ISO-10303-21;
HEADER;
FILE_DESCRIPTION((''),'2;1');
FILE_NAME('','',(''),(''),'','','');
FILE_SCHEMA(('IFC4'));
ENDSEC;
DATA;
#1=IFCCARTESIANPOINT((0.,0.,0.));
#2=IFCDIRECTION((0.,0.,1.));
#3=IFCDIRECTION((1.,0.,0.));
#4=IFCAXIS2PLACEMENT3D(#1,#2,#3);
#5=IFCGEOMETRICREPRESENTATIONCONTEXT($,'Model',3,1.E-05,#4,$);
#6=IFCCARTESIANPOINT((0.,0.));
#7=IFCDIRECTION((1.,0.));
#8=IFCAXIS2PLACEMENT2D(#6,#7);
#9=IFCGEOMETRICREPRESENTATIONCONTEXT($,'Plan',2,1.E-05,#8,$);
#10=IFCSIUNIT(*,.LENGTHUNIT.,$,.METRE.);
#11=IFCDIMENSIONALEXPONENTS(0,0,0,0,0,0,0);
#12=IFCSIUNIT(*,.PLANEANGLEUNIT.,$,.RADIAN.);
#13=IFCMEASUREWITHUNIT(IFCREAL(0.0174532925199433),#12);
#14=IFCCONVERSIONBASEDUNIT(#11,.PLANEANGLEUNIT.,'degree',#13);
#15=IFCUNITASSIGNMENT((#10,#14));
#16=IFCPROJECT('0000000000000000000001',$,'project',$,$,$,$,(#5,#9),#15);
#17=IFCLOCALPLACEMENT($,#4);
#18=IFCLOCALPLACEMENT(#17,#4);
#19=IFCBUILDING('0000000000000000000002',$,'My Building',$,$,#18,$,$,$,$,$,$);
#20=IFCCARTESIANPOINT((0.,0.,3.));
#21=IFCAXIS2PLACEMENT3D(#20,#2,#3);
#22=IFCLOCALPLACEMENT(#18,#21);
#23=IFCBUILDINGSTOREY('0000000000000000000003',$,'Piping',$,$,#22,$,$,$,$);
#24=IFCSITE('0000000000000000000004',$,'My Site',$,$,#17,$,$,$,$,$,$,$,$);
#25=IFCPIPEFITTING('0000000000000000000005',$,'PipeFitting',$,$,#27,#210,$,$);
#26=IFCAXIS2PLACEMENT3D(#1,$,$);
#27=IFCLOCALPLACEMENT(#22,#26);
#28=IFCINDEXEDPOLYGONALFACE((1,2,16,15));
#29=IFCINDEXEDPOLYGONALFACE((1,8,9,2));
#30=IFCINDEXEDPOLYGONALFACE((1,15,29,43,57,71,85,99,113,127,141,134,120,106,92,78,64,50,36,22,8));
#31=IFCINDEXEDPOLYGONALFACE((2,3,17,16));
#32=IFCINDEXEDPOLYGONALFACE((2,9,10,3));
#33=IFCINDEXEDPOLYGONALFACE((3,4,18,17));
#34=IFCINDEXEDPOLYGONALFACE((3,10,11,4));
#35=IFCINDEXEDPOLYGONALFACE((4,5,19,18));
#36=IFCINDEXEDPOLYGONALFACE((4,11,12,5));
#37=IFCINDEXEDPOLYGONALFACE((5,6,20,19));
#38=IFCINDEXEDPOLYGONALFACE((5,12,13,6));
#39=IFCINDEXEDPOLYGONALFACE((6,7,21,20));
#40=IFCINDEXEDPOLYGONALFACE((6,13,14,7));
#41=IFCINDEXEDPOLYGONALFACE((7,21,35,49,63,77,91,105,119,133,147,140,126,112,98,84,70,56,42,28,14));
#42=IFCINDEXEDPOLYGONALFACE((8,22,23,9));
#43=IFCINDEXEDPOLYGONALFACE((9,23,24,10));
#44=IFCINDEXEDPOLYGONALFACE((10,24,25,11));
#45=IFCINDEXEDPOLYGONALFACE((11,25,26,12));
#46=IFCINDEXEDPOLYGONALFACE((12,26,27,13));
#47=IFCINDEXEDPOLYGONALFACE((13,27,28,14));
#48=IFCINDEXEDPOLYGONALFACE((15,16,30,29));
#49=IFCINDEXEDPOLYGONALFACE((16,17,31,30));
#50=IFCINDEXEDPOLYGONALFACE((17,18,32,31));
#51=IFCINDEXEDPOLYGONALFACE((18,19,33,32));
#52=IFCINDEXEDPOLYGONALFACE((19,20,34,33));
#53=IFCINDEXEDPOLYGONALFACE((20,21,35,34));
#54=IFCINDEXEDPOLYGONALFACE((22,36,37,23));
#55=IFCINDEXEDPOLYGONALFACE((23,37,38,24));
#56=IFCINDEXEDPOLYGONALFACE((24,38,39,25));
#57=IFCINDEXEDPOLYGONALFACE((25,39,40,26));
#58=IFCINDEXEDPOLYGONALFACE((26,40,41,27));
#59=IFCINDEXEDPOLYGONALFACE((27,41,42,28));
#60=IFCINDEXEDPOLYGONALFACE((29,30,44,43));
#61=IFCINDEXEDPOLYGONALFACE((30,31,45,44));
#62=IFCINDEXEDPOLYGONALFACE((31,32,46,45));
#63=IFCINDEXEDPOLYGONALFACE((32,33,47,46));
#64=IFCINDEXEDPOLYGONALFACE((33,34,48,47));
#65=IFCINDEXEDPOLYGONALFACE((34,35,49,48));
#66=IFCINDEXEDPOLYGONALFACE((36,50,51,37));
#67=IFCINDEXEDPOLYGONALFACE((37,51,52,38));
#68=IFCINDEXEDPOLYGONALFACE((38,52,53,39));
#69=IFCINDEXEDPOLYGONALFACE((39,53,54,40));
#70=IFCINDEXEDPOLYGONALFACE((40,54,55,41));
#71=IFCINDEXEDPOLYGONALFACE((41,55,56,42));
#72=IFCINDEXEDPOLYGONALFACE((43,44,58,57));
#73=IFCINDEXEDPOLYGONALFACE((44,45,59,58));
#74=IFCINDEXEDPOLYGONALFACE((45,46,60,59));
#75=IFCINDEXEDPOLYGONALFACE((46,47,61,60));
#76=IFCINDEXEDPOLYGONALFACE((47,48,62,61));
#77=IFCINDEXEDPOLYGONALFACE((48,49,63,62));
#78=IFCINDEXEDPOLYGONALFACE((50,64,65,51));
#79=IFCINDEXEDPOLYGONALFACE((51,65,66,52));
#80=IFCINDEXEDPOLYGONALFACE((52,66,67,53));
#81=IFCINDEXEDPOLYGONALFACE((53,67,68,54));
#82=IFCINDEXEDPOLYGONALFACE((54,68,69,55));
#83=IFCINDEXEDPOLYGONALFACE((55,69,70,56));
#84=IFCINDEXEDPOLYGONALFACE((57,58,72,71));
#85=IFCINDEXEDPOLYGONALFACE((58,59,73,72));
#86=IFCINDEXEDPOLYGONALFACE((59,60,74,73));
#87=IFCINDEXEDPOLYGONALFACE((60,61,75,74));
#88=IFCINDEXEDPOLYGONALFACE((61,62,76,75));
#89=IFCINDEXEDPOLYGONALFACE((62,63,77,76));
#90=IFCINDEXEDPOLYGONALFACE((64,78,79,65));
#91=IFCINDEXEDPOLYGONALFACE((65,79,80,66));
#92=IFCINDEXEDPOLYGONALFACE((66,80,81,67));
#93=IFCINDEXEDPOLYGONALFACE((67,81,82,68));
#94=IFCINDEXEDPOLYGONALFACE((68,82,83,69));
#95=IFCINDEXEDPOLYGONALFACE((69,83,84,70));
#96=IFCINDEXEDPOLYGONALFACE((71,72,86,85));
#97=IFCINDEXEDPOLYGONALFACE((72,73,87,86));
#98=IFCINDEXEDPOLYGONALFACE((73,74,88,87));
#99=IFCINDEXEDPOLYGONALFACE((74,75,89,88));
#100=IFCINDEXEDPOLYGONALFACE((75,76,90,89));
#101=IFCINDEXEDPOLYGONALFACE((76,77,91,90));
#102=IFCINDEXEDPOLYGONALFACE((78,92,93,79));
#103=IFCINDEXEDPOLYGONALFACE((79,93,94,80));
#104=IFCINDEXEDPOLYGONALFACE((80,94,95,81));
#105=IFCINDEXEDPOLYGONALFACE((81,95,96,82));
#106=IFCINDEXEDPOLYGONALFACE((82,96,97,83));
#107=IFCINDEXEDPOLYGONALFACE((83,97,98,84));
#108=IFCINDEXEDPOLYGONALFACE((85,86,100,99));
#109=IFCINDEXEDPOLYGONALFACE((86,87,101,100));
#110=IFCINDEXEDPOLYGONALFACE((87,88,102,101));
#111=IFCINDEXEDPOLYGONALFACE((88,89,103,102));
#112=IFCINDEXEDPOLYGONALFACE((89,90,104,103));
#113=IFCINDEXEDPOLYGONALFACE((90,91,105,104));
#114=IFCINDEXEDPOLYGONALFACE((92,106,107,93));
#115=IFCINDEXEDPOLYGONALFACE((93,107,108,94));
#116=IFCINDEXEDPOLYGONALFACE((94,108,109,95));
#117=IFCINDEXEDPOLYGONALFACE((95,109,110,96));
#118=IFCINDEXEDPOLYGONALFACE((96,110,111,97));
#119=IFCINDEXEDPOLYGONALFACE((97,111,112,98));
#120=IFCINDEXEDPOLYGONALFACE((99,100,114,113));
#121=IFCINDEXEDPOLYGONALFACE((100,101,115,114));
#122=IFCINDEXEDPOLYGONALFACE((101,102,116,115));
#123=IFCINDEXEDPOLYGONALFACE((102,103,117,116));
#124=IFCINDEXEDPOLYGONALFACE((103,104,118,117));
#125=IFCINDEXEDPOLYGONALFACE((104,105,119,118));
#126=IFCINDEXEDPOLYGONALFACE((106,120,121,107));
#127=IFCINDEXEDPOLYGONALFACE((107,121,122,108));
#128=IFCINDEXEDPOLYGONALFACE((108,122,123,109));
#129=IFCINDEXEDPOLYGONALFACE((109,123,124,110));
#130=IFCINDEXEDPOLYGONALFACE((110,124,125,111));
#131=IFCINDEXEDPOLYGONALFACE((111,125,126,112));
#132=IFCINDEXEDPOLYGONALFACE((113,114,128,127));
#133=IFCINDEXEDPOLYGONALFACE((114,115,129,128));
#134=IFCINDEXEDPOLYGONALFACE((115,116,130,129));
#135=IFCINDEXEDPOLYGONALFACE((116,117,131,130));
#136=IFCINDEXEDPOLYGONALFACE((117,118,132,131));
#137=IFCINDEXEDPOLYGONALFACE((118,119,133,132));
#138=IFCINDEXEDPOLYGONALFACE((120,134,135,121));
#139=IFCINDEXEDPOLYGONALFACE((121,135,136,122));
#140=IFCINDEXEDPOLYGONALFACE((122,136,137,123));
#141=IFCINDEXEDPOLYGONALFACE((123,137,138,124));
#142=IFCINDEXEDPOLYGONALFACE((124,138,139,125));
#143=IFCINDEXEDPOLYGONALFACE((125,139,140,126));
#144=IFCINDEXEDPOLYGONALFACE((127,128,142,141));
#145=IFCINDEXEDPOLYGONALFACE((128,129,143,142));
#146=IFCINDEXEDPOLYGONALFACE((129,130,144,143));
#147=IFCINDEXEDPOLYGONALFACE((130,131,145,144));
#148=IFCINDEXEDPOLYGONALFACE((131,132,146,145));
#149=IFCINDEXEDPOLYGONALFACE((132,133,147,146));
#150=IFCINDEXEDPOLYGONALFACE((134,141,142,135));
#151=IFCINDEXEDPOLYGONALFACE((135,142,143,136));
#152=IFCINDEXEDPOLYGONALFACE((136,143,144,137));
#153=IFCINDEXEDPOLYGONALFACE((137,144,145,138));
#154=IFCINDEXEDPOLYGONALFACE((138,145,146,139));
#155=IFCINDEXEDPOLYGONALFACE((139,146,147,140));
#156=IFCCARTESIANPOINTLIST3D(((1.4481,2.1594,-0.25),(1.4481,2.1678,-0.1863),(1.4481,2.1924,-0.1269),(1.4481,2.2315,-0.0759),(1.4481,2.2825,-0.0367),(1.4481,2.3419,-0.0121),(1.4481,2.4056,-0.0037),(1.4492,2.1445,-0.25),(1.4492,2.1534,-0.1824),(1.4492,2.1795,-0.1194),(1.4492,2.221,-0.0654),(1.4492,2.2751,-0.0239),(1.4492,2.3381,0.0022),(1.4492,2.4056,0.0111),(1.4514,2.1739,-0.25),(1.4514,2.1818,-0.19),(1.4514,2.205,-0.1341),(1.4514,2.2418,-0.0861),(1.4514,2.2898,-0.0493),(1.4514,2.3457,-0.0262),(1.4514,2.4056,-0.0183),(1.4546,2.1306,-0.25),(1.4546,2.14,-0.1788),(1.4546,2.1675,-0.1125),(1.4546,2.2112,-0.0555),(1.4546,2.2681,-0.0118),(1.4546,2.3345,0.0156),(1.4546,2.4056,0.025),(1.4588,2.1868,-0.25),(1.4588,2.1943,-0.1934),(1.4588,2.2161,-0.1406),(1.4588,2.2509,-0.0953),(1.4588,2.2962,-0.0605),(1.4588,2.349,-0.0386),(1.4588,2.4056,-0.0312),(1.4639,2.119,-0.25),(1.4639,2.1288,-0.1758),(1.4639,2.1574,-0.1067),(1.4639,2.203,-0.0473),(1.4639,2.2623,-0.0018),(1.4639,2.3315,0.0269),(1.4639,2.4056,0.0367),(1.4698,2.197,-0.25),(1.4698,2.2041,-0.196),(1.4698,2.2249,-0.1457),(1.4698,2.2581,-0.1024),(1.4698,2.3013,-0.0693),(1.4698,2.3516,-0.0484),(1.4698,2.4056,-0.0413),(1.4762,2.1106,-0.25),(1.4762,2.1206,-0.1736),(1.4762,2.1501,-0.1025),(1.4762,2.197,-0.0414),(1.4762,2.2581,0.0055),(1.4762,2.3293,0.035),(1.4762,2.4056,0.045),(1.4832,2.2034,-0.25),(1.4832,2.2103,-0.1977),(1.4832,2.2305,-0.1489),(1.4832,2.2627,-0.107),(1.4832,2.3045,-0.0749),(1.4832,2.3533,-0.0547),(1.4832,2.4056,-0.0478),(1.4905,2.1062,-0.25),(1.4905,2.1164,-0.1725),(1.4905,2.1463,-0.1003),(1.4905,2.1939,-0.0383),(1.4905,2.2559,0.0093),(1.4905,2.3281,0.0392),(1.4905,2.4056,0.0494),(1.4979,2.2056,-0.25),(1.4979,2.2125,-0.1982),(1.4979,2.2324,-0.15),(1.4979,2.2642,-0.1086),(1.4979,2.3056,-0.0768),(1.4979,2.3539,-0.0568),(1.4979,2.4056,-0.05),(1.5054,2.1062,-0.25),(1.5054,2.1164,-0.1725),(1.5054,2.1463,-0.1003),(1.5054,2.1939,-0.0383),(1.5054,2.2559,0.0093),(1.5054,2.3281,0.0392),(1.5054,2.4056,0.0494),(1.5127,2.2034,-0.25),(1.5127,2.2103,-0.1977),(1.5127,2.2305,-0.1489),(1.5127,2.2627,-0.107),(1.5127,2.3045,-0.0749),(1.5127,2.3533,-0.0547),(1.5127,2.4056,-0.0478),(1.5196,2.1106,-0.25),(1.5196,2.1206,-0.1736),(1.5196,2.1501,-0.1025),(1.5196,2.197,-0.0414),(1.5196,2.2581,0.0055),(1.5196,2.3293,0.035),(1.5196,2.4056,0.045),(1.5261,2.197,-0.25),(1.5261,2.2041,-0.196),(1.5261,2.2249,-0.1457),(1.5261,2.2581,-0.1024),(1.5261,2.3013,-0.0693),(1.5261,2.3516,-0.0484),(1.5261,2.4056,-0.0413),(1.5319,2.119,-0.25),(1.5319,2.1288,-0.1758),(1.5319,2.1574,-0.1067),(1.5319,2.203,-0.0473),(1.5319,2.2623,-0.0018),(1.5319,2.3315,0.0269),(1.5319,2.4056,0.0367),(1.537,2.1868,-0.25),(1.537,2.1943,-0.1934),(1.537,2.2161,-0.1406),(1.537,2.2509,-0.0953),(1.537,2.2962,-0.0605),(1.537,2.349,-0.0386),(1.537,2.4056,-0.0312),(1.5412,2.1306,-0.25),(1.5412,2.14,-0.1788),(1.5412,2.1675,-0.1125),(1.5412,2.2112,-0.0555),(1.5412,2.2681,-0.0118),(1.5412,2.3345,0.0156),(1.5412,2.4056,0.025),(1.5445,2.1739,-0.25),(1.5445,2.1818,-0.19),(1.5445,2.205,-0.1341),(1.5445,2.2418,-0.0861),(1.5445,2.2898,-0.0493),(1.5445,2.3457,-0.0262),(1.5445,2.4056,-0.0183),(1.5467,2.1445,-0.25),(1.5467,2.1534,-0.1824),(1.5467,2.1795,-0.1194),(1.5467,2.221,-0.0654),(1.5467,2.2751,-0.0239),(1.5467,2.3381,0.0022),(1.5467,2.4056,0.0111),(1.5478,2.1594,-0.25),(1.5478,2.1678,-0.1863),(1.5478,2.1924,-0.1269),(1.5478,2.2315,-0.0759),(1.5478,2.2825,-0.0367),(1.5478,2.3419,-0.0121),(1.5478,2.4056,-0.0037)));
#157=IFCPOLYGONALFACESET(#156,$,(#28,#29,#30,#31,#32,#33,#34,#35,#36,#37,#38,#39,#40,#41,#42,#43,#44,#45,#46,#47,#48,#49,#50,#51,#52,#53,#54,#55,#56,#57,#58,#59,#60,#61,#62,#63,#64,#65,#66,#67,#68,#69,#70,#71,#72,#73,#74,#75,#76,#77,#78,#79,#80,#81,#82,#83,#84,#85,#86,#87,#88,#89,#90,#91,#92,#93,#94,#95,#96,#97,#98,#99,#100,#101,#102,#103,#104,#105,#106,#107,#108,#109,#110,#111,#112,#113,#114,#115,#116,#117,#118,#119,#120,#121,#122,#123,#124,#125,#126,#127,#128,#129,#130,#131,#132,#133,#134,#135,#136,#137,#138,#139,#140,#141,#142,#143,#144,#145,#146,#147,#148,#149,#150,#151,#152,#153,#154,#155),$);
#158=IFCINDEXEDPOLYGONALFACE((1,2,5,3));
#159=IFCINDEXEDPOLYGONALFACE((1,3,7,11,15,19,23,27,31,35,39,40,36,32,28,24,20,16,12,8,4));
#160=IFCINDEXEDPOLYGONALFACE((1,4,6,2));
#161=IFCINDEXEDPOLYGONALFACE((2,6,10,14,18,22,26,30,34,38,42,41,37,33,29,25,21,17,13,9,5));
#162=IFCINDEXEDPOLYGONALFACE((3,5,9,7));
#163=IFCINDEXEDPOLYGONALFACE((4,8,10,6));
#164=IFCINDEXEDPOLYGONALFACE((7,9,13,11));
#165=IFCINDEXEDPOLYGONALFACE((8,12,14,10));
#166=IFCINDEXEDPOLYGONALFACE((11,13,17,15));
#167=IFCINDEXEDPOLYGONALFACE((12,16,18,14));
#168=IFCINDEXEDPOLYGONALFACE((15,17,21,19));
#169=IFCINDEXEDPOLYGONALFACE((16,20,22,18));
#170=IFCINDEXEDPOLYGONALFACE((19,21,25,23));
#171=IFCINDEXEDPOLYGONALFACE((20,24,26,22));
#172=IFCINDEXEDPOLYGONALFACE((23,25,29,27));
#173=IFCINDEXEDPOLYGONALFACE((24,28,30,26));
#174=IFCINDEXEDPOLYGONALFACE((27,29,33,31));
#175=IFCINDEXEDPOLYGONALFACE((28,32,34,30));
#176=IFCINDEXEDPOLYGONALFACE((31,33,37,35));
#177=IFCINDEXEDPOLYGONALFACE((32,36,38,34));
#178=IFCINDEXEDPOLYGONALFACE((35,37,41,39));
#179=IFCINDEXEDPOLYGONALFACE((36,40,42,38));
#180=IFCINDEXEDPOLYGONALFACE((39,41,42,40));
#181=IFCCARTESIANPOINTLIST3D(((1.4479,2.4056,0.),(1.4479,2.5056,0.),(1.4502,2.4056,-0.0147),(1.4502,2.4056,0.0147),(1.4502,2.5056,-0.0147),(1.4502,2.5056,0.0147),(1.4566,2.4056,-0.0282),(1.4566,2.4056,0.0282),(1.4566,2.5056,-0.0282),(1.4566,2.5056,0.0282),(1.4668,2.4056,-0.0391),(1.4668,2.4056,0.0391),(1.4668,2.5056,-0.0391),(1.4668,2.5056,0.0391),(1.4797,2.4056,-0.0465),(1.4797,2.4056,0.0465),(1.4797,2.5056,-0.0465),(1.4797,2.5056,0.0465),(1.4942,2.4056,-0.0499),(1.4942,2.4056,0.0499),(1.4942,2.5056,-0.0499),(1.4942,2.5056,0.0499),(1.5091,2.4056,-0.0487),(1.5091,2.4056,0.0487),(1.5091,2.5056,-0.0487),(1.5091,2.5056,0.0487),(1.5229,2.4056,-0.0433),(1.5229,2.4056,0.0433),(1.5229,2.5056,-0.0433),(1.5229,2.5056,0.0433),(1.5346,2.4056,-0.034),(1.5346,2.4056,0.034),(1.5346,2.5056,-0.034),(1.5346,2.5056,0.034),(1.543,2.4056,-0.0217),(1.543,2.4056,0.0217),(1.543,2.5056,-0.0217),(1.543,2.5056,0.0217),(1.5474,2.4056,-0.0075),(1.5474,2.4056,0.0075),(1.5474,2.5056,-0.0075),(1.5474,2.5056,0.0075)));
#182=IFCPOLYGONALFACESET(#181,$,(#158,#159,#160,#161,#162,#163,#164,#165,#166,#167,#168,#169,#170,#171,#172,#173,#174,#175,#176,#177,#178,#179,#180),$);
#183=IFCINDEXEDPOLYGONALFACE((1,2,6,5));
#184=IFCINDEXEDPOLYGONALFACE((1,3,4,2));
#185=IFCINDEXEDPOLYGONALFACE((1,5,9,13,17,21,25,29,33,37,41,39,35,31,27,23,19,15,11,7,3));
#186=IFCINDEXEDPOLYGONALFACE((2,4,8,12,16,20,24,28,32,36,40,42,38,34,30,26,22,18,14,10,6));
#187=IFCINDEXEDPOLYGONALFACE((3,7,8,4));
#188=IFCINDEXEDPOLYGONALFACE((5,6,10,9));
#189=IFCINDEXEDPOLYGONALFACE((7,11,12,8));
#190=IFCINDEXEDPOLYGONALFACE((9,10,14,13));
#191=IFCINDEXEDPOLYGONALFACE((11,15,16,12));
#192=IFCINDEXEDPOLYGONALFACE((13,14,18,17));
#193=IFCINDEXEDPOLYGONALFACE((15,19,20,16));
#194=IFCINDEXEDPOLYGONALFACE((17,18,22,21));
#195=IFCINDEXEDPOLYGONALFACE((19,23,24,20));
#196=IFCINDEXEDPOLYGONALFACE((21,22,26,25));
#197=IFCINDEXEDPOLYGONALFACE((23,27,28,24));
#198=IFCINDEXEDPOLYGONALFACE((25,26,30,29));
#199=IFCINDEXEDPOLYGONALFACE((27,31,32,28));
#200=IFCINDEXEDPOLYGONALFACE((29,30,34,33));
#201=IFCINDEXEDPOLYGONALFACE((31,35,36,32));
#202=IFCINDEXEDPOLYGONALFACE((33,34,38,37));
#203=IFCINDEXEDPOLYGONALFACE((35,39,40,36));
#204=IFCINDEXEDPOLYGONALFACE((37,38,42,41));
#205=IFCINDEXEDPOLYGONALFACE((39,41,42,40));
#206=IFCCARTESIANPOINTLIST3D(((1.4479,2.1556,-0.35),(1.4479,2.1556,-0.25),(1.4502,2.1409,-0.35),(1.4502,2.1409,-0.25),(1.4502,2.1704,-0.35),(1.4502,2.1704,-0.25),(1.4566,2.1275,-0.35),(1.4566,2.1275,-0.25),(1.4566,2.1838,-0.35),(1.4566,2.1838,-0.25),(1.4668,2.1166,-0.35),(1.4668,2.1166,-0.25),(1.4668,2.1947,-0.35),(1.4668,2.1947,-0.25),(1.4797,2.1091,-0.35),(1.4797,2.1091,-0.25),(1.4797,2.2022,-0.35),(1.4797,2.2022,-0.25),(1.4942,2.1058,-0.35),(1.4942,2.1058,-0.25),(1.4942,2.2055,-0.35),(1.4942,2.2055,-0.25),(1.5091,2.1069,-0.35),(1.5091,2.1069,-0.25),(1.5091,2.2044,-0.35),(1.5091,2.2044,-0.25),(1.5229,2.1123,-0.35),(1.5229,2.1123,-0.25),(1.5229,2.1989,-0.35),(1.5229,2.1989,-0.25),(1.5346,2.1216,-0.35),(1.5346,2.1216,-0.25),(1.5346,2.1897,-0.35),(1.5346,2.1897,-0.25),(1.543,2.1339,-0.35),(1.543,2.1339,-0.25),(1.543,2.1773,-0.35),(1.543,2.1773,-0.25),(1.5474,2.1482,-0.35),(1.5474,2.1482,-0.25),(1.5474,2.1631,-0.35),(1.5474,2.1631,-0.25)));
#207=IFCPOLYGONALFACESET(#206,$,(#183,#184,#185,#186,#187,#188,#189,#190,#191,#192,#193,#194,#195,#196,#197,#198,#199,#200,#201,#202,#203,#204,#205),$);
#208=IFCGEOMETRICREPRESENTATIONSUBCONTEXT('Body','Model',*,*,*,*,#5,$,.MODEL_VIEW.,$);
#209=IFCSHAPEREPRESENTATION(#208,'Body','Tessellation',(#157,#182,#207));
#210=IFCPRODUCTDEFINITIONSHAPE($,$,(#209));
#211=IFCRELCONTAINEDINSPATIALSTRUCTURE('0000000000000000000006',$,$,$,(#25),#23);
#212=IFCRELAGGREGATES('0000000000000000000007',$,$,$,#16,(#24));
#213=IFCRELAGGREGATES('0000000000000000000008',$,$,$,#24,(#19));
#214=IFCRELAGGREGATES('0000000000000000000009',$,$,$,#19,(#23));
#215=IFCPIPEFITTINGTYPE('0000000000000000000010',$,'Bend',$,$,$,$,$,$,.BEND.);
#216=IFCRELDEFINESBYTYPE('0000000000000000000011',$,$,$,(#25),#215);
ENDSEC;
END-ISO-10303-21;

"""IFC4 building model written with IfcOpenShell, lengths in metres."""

from ifc_helpers import new_model, entity, si_unit, converted_unit, frame, origin_with_axes, origin_2d_with_axis, place, context, subcontext, project, spatial, circle, extrude, source, transform, mapped, type_object, type_shapes, element, save


model = new_model("IFC4")

# Units and contexts
model_context = context("Model", 3, precision=1e-05, world=origin_with_axes())
plan_context = context("Plan", 2, precision=1e-05, world=origin_2d_with_axis())
body_context = subcontext(model_context, "Body", "Model", "MODEL_VIEW")
ifc_project = project(units=[si_unit("LENGTHUNIT", "METRE"), converted_unit("PLANEANGLEUNIT", "degree", entity("IfcReal", 0.0174532925199433), si_unit("PLANEANGLEUNIT", "RADIAN"), dimensions=[0, 0, 0, 0, 0, 0, 0])], contexts=[model_context, plan_context])

# Site, building, storey
site_placement = place(None, origin_with_axes())
site = spatial("IfcSite", under=ifc_project, at=site_placement, Name="My Site")
building_placement = place(site_placement, origin_with_axes())
building = spatial("IfcBuilding", under=site, at=building_placement, Name="My Building")
storey_placement = place(building_placement, frame((0.0, 0.0, 3.0), z_axis=(0.0, 0.0, 1.0), x_axis=(1.0, 0.0, 0.0)))
storey = spatial("IfcBuildingStorey", under=building, at=storey_placement, Name="Piping")

# Pipe fitting
pipe_fitting_type = type_object("IfcPipeFittingType", Name="Bend", PredefinedType="BEND")
shared_shape = source(origin_with_axes(), body_context, "Body", "SolidModel", [
    entity("IfcSweptDiskSolid", entity("IfcIndexedPolyCurve", entity("IfcCartesianPointList3D", [[0.0, 0.0, -0.1], [0.0, -0.0732, -0.2768], [0.0, -0.25, -0.35]]), [entity("IfcArcIndex", [1, 2, 3])]), 0.05),
    extrude(circle(Radius=0.05), origin_with_axes(), (0.0, 0.0, -1.0), 0.1),
    extrude(circle(Radius=0.05), frame((0.0, -0.25, -0.35), z_axis=(0.0, -1.0, 0.0), x_axis=(1.0, 0.0, 0.0)), (0.0, 0.0, 1.0), 0.1),
])
type_shapes(pipe_fitting_type, [shared_shape])
for number, where, z_axis, x_axis, name in (
    (1, (1.4979, 2.5056, 0.0), (0.0, 1.0, 0.0), (-1.0, 0.0, 0.0), "PipeFitting"),
):
    element("IfcPipeFitting", number, at=place(storey_placement, frame(where, z_axis=z_axis, x_axis=x_axis)), inside=storey, type_object=pipe_fitting_type, Name=name, context=body_context, shape_type="MappedRepresentation", body=[
        mapped(shared_shape, transform((0.0, 0.0, 0.0), x_axis=(1.0, 0.0, 0.0), y_axis=(0.0, 1.0, 0.0), z_axis=(0.0, 0.0, 1.0), scale=1.0)),
    ])

save(model, "model.ifc")
